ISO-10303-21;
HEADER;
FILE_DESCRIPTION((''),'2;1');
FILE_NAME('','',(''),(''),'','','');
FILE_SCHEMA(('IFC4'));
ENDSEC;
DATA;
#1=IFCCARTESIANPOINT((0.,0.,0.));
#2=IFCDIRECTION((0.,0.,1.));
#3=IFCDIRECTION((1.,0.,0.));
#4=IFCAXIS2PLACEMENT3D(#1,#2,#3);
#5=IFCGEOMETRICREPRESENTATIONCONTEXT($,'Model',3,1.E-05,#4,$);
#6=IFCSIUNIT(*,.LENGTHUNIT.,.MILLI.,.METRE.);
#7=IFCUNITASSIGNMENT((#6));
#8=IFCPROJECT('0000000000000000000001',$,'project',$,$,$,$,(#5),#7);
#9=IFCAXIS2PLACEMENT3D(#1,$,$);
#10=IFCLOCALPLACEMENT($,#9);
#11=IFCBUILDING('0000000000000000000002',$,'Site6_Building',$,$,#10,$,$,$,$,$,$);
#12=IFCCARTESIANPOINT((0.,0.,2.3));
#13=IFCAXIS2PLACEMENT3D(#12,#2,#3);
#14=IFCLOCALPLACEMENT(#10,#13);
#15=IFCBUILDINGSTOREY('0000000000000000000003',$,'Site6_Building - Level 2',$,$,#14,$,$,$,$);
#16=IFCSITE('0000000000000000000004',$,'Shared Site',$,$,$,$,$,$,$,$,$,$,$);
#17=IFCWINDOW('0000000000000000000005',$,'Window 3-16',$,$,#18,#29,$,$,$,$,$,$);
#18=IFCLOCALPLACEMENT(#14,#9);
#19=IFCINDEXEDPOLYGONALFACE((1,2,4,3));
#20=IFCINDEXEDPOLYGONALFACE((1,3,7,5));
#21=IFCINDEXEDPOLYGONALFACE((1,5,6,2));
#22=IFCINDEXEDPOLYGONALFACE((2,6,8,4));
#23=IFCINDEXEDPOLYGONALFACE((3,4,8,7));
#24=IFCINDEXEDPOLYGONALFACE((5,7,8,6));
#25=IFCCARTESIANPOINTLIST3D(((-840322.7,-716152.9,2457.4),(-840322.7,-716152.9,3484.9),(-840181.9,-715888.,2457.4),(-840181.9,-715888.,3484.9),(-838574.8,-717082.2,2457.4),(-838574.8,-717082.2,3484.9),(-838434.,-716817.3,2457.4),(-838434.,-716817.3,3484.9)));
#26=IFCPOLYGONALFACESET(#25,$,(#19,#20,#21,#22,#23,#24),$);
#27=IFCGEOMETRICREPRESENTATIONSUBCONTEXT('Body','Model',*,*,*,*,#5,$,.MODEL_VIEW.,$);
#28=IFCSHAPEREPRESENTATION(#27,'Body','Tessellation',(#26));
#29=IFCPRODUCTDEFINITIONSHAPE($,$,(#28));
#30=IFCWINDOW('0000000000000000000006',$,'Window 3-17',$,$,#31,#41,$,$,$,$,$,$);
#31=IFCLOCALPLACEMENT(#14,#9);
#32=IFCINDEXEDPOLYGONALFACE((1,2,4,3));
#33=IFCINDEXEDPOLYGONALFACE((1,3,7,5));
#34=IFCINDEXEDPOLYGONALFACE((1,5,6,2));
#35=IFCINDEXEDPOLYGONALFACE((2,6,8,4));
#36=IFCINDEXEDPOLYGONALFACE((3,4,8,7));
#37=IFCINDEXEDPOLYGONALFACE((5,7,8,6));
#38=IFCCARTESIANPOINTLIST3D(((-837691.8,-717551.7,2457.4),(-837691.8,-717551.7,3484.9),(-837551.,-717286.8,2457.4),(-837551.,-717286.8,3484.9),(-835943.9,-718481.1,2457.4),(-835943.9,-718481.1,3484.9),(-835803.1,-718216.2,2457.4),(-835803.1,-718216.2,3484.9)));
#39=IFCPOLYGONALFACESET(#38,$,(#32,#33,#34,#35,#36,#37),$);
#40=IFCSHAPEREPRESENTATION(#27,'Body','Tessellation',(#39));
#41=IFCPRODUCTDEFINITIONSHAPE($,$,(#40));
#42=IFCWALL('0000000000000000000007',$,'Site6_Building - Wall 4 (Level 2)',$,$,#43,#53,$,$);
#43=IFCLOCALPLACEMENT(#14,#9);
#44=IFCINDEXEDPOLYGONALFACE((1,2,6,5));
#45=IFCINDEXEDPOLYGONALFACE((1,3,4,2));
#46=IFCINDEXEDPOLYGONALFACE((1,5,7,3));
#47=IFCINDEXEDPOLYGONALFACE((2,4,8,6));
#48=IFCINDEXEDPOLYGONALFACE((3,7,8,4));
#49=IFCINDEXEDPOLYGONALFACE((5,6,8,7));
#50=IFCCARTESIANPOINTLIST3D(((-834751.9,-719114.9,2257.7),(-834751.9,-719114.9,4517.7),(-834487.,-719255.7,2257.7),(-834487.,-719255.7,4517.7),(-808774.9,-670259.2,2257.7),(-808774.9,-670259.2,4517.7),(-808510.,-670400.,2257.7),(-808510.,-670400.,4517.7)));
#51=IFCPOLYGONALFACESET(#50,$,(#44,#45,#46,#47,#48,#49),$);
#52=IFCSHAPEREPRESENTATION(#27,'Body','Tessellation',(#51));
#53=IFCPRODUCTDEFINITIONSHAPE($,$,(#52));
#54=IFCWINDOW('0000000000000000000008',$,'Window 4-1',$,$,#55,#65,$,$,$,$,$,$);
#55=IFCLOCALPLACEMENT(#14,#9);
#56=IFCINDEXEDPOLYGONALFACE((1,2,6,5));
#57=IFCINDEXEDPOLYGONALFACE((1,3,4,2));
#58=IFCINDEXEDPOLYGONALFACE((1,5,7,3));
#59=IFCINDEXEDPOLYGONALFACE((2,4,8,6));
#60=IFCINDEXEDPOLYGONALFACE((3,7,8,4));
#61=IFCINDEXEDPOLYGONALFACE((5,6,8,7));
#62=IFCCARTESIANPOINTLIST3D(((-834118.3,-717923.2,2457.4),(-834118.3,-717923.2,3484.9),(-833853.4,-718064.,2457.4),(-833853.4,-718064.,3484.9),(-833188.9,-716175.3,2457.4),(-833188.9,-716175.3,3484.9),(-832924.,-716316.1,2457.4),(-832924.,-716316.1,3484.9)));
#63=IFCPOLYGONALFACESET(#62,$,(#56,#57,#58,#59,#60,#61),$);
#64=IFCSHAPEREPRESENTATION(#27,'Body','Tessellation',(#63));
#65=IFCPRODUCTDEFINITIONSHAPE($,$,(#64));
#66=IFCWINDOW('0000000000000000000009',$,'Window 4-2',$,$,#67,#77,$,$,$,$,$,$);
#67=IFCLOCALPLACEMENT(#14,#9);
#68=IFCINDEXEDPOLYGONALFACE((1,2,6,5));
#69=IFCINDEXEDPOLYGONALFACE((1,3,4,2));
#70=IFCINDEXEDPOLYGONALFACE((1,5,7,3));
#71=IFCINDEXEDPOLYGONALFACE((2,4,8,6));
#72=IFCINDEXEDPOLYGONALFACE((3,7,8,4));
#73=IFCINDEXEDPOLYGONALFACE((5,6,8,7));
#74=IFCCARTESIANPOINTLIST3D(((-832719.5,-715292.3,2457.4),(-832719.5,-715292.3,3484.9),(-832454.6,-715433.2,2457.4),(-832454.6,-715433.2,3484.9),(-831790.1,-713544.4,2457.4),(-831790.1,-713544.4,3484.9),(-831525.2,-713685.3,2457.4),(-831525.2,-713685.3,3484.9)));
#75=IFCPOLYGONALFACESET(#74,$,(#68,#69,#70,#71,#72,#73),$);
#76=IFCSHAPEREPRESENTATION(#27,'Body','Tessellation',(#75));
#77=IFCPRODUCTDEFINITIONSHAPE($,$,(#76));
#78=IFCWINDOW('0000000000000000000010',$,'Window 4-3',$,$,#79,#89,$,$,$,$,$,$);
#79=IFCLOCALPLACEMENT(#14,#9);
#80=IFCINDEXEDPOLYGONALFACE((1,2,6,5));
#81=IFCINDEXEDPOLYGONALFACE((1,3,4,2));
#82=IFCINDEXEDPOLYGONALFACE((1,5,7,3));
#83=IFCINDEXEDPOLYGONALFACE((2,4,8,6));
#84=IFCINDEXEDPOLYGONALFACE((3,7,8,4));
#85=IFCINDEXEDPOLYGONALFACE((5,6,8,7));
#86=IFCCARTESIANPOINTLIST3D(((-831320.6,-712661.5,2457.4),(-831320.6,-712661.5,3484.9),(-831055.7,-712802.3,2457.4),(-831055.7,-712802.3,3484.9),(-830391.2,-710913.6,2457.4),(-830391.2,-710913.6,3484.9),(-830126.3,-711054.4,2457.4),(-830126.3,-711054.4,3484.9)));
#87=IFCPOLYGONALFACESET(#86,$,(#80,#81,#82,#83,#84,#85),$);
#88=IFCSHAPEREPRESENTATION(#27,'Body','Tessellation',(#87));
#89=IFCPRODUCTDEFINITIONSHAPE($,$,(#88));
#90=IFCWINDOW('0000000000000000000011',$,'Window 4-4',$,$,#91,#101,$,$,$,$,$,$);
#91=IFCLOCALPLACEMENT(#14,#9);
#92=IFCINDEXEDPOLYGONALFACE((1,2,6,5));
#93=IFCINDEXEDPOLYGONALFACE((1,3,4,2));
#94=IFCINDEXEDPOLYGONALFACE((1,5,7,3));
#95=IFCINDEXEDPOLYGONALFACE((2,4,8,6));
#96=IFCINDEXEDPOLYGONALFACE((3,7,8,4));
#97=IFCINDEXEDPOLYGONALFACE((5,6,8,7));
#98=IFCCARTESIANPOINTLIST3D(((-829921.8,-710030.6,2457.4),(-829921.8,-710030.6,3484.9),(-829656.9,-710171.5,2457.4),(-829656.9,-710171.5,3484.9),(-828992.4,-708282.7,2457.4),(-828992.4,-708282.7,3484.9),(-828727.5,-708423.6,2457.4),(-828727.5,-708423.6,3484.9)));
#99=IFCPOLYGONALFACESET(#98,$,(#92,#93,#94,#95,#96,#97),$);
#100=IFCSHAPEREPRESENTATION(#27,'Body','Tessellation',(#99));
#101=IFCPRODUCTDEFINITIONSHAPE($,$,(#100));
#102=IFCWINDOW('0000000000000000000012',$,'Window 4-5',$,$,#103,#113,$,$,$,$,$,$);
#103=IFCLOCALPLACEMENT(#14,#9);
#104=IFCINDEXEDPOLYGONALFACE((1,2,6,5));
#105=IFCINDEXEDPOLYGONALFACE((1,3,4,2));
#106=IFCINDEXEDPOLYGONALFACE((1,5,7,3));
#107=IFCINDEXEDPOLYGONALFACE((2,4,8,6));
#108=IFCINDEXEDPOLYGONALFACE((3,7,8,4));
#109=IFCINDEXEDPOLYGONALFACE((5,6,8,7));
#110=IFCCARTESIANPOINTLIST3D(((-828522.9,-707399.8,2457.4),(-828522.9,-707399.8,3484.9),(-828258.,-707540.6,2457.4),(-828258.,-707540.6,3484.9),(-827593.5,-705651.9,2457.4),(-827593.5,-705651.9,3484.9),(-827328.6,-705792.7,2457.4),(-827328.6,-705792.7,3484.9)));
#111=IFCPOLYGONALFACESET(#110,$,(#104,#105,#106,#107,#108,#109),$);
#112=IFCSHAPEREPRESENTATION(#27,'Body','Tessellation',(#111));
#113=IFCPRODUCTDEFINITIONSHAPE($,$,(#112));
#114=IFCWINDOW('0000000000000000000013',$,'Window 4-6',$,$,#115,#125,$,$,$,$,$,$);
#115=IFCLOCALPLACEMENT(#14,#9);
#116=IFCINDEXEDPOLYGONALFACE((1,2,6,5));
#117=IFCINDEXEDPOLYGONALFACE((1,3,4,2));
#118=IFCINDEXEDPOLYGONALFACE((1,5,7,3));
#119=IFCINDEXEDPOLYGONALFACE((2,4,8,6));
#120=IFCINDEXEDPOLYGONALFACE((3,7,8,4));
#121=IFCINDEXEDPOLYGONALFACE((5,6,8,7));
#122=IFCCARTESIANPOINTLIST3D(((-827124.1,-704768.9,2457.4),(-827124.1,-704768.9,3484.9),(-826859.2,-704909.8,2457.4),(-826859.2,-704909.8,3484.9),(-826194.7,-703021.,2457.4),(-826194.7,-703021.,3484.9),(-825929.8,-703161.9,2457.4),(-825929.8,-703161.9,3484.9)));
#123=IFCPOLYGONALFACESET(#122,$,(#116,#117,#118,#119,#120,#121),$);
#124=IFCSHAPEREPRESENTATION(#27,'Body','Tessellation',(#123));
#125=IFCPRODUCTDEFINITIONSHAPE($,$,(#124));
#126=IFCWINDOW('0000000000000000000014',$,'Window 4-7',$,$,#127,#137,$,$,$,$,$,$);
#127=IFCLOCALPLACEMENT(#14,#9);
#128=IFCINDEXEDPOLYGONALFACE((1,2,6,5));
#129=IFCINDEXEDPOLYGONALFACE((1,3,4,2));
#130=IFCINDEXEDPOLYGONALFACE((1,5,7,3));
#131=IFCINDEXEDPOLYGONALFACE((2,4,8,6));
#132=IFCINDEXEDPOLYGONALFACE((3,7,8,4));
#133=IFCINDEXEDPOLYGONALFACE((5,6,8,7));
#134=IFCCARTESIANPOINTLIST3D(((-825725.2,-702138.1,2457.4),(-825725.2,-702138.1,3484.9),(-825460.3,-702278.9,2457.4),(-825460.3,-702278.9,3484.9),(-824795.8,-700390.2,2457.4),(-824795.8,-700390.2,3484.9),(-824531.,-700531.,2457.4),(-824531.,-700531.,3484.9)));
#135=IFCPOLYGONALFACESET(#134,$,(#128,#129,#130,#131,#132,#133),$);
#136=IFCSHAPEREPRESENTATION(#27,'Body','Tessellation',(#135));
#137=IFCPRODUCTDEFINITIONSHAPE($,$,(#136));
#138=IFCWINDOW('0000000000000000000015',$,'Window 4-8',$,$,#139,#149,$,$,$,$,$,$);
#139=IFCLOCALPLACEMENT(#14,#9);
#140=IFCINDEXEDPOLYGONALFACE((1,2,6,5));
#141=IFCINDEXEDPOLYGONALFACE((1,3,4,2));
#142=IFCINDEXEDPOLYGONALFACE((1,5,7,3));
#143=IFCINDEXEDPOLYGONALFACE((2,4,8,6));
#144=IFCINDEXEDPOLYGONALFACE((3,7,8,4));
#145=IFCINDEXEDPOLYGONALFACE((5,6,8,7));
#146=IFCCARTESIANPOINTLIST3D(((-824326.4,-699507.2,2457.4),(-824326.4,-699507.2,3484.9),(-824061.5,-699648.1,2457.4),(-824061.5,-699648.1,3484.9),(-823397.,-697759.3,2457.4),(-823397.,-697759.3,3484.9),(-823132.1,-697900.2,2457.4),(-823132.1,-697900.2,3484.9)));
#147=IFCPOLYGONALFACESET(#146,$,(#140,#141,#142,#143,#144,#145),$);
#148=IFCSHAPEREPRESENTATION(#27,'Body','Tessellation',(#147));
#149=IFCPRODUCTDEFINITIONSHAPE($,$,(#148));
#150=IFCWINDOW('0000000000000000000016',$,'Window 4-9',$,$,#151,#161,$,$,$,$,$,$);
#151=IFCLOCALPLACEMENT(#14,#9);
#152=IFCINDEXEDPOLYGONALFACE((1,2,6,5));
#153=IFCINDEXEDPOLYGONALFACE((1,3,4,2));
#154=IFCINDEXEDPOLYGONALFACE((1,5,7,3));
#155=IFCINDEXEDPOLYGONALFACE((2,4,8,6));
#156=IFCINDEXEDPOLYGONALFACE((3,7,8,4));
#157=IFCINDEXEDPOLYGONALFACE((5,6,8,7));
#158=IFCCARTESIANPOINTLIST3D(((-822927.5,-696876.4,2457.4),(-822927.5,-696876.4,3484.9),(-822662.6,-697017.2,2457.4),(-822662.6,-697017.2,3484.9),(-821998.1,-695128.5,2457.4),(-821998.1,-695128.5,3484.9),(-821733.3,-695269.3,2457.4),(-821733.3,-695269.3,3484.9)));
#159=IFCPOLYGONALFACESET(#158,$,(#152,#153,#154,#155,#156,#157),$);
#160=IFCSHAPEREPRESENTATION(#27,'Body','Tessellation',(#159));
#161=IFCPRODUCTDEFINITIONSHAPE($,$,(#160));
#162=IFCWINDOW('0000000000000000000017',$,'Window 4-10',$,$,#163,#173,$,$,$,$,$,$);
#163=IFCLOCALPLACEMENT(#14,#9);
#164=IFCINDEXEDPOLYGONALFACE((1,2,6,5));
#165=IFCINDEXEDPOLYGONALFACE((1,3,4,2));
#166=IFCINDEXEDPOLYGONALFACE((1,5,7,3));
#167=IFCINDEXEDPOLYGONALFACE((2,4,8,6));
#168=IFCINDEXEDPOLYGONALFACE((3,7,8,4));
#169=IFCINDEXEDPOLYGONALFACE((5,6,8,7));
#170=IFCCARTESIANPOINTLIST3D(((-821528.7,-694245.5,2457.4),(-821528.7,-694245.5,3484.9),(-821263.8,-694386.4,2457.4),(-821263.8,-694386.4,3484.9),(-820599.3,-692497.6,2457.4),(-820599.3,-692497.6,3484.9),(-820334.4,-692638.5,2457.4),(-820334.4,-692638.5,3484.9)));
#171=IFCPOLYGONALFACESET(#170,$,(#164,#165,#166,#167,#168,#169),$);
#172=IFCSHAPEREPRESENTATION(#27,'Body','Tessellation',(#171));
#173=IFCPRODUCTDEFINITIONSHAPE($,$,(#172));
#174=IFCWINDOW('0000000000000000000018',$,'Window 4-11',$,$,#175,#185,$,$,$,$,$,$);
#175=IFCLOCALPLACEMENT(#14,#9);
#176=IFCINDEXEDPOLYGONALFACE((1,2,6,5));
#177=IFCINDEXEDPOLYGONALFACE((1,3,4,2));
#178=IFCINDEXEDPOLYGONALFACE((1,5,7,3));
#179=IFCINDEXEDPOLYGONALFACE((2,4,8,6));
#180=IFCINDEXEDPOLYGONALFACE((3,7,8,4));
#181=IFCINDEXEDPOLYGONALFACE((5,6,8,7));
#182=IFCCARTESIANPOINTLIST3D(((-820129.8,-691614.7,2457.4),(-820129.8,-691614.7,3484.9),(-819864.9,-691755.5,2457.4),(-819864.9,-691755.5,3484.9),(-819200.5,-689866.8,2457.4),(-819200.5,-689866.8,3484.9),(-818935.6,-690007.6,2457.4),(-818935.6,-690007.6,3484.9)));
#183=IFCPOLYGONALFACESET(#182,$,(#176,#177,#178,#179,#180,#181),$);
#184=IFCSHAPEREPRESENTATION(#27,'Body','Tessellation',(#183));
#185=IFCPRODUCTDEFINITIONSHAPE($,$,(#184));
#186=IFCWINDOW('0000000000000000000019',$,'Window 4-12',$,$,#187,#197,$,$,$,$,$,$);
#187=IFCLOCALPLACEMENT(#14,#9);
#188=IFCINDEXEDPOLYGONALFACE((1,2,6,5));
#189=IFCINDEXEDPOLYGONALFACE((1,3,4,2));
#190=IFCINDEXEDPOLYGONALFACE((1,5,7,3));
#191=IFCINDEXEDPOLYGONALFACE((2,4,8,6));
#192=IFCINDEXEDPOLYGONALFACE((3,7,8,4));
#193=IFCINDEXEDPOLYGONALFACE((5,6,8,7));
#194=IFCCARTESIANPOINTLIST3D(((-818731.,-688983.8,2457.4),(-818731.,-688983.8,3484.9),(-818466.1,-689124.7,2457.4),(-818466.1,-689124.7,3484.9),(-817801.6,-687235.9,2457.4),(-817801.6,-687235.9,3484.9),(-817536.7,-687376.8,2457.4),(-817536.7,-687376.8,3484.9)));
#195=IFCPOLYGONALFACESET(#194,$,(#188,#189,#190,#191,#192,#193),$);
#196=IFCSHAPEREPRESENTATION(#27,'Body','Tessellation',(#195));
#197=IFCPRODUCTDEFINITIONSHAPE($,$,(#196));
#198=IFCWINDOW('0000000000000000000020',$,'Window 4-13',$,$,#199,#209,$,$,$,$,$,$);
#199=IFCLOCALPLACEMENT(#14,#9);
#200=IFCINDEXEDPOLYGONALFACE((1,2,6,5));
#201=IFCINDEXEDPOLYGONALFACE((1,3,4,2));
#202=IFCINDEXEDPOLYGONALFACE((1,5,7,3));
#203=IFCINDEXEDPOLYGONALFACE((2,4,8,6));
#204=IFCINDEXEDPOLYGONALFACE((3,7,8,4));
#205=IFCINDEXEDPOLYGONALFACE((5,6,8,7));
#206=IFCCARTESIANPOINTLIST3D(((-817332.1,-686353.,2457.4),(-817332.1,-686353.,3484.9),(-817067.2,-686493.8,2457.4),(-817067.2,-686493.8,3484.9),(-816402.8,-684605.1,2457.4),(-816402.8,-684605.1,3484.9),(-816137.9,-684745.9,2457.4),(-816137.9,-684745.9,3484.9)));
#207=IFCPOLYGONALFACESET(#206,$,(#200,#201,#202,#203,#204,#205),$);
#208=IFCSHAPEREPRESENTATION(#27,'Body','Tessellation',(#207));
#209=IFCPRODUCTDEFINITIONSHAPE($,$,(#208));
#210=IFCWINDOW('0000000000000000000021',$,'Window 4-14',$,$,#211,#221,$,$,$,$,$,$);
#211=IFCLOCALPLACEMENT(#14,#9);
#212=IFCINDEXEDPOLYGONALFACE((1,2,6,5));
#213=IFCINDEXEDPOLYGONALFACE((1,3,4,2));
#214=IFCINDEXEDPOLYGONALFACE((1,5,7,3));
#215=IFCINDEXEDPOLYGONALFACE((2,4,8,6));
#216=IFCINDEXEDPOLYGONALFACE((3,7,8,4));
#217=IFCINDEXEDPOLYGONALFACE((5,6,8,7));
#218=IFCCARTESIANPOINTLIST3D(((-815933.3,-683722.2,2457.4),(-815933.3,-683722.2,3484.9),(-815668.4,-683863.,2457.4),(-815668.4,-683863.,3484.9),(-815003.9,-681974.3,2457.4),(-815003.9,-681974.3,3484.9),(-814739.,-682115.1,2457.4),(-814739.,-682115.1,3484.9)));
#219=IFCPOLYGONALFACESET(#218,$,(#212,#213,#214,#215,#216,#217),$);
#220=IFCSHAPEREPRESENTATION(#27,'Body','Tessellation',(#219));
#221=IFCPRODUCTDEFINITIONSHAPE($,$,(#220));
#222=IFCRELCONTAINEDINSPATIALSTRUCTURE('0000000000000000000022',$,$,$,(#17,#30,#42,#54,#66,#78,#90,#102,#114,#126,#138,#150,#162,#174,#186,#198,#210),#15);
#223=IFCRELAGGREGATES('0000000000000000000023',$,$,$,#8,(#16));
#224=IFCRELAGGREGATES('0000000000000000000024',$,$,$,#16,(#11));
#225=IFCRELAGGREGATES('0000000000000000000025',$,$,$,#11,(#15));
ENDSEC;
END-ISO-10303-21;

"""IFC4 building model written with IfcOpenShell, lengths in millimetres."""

from ifc_helpers import new_model, si_unit, frame, origin, origin_with_axes, place, context, subcontext, project, spatial, indexed_curve, outline, extrude, element, save


model = new_model("IFC4")

# Units and contexts
model_context = context("Model", 3, precision=1e-05, world=origin_with_axes())
body_context = subcontext(model_context, "Body", "Model", "MODEL_VIEW")
ifc_project = project(units=[si_unit("LENGTHUNIT", "METRE", prefix="MILLI")], contexts=[model_context])

# Site, building, storey
site = spatial("IfcSite", under=ifc_project, Name="Shared Site")
building_placement = place(None, origin())
building = spatial("IfcBuilding", under=site, at=building_placement, Name="Site6_Building")
storey_placement = place(building_placement, frame((0.0, 0.0, 2.3), z_axis=(0.0, 0.0, 1.0), x_axis=(1.0, 0.0, 0.0)))
storey = spatial("IfcBuildingStorey", under=building, at=storey_placement, Name="Site6_Building - Level 2")

# Windows
for number, where, z_axis, x_axis, name in (
    (1, (-840322.7, -716152.9, 2457.4), (0.0, 0.0, 1.0), (0.882948, -0.469472, 0.0), "Window 3-16"),
    (2, (-837691.8, -717551.7, 2457.4), (0.0, 0.0, 1.0), (0.882948, -0.469472, 0.0), "Window 3-17"),
):
    element("IfcWindow", number, at=place(storey_placement, frame(where, z_axis=z_axis, x_axis=x_axis)), inside=storey, Name=name, context=body_context, shape_type="SweptSolid", body=[
        extrude(outline(indexed_curve([(0.0, 0.0), (0.0, 300.0), (1979.6, 300.0), (1979.6, 0.0), (0.0, 0.0)], self_intersect=False)), origin_with_axes(), (0.0, 0.0, 1.0), 1027.5),
    ])

# Wall
wall_1_placement = place(storey_placement, frame((-834487.0, -719255.7, 2257.7), z_axis=(0.0, 0.0, 1.0), x_axis=(0.469472, 0.882948, 0.0)))
element("IfcWall", 3, at=wall_1_placement, inside=storey, Name="Site6_Building - Wall 4 (Level 2)", context=body_context, shape_type="SweptSolid", body=[
    extrude(outline(indexed_curve([(0.0, 0.0), (0.0, 300.0), (55332.5, 300.0), (55332.5, 0.0), (0.0, 0.0)], self_intersect=False)), origin_with_axes(), (0.0, 0.0, 1.0), 2260.0),
])

# Windows
for number, where, z_axis, x_axis, name in (
    (4, (-833853.4, -718064.0, 2457.4), (0.0, 0.0, 1.0), (0.469472, 0.882948, 0.0), "Window 4-1"),
    (5, (-832454.6, -715433.2, 2457.4), (0.0, 0.0, 1.0), (0.469472, 0.882948, 0.0), "Window 4-2"),
    (6, (-831055.7, -712802.3, 2457.4), (0.0, 0.0, 1.0), (0.469472, 0.882948, 0.0), "Window 4-3"),
    (7, (-829656.9, -710171.5, 2457.4), (0.0, 0.0, 1.0), (0.469472, 0.882948, 0.0), "Window 4-4"),
    (8, (-828258.0, -707540.6, 2457.4), (0.0, 0.0, 1.0), (0.469472, 0.882948, 0.0), "Window 4-5"),
    (9, (-826859.2, -704909.8, 2457.4), (0.0, 0.0, 1.0), (0.469472, 0.882948, 0.0), "Window 4-6"),
    (10, (-825460.3, -702278.9, 2457.4), (0.0, 0.0, 1.0), (0.469472, 0.882948, 0.0), "Window 4-7"),
    (11, (-824061.5, -699648.1, 2457.4), (0.0, 0.0, 1.0), (0.469472, 0.882948, 0.0), "Window 4-8"),
    (12, (-822662.6, -697017.2, 2457.4), (0.0, 0.0, 1.0), (0.469472, 0.882948, 0.0), "Window 4-9"),
    (13, (-821263.8, -694386.4, 2457.4), (0.0, 0.0, 1.0), (0.469472, 0.882948, 0.0), "Window 4-10"),
    (14, (-819864.9, -691755.5, 2457.4), (0.0, 0.0, 1.0), (0.469472, 0.882948, 0.0), "Window 4-11"),
    (15, (-818466.1, -689124.7, 2457.4), (0.0, 0.0, 1.0), (0.469472, 0.882948, 0.0), "Window 4-12"),
    (16, (-817067.2, -686493.8, 2457.4), (0.0, 0.0, 1.0), (0.469472, 0.882948, 0.0), "Window 4-13"),
    (17, (-815668.4, -683863.0, 2457.4), (0.0, 0.0, 1.0), (0.469472, 0.882948, 0.0), "Window 4-14"),
):
    element("IfcWindow", number, at=place(storey_placement, frame(where, z_axis=z_axis, x_axis=x_axis)), inside=storey, Name=name, context=body_context, shape_type="SweptSolid", body=[
        extrude(outline(indexed_curve([(0.0, 0.0), (0.0, 300.0), (1979.6, 300.0), (1979.6, 0.0), (0.0, 0.0)], self_intersect=False)), origin_with_axes(), (0.0, 0.0, 1.0), 1027.5),
    ])

save(model, "model.ifc")
